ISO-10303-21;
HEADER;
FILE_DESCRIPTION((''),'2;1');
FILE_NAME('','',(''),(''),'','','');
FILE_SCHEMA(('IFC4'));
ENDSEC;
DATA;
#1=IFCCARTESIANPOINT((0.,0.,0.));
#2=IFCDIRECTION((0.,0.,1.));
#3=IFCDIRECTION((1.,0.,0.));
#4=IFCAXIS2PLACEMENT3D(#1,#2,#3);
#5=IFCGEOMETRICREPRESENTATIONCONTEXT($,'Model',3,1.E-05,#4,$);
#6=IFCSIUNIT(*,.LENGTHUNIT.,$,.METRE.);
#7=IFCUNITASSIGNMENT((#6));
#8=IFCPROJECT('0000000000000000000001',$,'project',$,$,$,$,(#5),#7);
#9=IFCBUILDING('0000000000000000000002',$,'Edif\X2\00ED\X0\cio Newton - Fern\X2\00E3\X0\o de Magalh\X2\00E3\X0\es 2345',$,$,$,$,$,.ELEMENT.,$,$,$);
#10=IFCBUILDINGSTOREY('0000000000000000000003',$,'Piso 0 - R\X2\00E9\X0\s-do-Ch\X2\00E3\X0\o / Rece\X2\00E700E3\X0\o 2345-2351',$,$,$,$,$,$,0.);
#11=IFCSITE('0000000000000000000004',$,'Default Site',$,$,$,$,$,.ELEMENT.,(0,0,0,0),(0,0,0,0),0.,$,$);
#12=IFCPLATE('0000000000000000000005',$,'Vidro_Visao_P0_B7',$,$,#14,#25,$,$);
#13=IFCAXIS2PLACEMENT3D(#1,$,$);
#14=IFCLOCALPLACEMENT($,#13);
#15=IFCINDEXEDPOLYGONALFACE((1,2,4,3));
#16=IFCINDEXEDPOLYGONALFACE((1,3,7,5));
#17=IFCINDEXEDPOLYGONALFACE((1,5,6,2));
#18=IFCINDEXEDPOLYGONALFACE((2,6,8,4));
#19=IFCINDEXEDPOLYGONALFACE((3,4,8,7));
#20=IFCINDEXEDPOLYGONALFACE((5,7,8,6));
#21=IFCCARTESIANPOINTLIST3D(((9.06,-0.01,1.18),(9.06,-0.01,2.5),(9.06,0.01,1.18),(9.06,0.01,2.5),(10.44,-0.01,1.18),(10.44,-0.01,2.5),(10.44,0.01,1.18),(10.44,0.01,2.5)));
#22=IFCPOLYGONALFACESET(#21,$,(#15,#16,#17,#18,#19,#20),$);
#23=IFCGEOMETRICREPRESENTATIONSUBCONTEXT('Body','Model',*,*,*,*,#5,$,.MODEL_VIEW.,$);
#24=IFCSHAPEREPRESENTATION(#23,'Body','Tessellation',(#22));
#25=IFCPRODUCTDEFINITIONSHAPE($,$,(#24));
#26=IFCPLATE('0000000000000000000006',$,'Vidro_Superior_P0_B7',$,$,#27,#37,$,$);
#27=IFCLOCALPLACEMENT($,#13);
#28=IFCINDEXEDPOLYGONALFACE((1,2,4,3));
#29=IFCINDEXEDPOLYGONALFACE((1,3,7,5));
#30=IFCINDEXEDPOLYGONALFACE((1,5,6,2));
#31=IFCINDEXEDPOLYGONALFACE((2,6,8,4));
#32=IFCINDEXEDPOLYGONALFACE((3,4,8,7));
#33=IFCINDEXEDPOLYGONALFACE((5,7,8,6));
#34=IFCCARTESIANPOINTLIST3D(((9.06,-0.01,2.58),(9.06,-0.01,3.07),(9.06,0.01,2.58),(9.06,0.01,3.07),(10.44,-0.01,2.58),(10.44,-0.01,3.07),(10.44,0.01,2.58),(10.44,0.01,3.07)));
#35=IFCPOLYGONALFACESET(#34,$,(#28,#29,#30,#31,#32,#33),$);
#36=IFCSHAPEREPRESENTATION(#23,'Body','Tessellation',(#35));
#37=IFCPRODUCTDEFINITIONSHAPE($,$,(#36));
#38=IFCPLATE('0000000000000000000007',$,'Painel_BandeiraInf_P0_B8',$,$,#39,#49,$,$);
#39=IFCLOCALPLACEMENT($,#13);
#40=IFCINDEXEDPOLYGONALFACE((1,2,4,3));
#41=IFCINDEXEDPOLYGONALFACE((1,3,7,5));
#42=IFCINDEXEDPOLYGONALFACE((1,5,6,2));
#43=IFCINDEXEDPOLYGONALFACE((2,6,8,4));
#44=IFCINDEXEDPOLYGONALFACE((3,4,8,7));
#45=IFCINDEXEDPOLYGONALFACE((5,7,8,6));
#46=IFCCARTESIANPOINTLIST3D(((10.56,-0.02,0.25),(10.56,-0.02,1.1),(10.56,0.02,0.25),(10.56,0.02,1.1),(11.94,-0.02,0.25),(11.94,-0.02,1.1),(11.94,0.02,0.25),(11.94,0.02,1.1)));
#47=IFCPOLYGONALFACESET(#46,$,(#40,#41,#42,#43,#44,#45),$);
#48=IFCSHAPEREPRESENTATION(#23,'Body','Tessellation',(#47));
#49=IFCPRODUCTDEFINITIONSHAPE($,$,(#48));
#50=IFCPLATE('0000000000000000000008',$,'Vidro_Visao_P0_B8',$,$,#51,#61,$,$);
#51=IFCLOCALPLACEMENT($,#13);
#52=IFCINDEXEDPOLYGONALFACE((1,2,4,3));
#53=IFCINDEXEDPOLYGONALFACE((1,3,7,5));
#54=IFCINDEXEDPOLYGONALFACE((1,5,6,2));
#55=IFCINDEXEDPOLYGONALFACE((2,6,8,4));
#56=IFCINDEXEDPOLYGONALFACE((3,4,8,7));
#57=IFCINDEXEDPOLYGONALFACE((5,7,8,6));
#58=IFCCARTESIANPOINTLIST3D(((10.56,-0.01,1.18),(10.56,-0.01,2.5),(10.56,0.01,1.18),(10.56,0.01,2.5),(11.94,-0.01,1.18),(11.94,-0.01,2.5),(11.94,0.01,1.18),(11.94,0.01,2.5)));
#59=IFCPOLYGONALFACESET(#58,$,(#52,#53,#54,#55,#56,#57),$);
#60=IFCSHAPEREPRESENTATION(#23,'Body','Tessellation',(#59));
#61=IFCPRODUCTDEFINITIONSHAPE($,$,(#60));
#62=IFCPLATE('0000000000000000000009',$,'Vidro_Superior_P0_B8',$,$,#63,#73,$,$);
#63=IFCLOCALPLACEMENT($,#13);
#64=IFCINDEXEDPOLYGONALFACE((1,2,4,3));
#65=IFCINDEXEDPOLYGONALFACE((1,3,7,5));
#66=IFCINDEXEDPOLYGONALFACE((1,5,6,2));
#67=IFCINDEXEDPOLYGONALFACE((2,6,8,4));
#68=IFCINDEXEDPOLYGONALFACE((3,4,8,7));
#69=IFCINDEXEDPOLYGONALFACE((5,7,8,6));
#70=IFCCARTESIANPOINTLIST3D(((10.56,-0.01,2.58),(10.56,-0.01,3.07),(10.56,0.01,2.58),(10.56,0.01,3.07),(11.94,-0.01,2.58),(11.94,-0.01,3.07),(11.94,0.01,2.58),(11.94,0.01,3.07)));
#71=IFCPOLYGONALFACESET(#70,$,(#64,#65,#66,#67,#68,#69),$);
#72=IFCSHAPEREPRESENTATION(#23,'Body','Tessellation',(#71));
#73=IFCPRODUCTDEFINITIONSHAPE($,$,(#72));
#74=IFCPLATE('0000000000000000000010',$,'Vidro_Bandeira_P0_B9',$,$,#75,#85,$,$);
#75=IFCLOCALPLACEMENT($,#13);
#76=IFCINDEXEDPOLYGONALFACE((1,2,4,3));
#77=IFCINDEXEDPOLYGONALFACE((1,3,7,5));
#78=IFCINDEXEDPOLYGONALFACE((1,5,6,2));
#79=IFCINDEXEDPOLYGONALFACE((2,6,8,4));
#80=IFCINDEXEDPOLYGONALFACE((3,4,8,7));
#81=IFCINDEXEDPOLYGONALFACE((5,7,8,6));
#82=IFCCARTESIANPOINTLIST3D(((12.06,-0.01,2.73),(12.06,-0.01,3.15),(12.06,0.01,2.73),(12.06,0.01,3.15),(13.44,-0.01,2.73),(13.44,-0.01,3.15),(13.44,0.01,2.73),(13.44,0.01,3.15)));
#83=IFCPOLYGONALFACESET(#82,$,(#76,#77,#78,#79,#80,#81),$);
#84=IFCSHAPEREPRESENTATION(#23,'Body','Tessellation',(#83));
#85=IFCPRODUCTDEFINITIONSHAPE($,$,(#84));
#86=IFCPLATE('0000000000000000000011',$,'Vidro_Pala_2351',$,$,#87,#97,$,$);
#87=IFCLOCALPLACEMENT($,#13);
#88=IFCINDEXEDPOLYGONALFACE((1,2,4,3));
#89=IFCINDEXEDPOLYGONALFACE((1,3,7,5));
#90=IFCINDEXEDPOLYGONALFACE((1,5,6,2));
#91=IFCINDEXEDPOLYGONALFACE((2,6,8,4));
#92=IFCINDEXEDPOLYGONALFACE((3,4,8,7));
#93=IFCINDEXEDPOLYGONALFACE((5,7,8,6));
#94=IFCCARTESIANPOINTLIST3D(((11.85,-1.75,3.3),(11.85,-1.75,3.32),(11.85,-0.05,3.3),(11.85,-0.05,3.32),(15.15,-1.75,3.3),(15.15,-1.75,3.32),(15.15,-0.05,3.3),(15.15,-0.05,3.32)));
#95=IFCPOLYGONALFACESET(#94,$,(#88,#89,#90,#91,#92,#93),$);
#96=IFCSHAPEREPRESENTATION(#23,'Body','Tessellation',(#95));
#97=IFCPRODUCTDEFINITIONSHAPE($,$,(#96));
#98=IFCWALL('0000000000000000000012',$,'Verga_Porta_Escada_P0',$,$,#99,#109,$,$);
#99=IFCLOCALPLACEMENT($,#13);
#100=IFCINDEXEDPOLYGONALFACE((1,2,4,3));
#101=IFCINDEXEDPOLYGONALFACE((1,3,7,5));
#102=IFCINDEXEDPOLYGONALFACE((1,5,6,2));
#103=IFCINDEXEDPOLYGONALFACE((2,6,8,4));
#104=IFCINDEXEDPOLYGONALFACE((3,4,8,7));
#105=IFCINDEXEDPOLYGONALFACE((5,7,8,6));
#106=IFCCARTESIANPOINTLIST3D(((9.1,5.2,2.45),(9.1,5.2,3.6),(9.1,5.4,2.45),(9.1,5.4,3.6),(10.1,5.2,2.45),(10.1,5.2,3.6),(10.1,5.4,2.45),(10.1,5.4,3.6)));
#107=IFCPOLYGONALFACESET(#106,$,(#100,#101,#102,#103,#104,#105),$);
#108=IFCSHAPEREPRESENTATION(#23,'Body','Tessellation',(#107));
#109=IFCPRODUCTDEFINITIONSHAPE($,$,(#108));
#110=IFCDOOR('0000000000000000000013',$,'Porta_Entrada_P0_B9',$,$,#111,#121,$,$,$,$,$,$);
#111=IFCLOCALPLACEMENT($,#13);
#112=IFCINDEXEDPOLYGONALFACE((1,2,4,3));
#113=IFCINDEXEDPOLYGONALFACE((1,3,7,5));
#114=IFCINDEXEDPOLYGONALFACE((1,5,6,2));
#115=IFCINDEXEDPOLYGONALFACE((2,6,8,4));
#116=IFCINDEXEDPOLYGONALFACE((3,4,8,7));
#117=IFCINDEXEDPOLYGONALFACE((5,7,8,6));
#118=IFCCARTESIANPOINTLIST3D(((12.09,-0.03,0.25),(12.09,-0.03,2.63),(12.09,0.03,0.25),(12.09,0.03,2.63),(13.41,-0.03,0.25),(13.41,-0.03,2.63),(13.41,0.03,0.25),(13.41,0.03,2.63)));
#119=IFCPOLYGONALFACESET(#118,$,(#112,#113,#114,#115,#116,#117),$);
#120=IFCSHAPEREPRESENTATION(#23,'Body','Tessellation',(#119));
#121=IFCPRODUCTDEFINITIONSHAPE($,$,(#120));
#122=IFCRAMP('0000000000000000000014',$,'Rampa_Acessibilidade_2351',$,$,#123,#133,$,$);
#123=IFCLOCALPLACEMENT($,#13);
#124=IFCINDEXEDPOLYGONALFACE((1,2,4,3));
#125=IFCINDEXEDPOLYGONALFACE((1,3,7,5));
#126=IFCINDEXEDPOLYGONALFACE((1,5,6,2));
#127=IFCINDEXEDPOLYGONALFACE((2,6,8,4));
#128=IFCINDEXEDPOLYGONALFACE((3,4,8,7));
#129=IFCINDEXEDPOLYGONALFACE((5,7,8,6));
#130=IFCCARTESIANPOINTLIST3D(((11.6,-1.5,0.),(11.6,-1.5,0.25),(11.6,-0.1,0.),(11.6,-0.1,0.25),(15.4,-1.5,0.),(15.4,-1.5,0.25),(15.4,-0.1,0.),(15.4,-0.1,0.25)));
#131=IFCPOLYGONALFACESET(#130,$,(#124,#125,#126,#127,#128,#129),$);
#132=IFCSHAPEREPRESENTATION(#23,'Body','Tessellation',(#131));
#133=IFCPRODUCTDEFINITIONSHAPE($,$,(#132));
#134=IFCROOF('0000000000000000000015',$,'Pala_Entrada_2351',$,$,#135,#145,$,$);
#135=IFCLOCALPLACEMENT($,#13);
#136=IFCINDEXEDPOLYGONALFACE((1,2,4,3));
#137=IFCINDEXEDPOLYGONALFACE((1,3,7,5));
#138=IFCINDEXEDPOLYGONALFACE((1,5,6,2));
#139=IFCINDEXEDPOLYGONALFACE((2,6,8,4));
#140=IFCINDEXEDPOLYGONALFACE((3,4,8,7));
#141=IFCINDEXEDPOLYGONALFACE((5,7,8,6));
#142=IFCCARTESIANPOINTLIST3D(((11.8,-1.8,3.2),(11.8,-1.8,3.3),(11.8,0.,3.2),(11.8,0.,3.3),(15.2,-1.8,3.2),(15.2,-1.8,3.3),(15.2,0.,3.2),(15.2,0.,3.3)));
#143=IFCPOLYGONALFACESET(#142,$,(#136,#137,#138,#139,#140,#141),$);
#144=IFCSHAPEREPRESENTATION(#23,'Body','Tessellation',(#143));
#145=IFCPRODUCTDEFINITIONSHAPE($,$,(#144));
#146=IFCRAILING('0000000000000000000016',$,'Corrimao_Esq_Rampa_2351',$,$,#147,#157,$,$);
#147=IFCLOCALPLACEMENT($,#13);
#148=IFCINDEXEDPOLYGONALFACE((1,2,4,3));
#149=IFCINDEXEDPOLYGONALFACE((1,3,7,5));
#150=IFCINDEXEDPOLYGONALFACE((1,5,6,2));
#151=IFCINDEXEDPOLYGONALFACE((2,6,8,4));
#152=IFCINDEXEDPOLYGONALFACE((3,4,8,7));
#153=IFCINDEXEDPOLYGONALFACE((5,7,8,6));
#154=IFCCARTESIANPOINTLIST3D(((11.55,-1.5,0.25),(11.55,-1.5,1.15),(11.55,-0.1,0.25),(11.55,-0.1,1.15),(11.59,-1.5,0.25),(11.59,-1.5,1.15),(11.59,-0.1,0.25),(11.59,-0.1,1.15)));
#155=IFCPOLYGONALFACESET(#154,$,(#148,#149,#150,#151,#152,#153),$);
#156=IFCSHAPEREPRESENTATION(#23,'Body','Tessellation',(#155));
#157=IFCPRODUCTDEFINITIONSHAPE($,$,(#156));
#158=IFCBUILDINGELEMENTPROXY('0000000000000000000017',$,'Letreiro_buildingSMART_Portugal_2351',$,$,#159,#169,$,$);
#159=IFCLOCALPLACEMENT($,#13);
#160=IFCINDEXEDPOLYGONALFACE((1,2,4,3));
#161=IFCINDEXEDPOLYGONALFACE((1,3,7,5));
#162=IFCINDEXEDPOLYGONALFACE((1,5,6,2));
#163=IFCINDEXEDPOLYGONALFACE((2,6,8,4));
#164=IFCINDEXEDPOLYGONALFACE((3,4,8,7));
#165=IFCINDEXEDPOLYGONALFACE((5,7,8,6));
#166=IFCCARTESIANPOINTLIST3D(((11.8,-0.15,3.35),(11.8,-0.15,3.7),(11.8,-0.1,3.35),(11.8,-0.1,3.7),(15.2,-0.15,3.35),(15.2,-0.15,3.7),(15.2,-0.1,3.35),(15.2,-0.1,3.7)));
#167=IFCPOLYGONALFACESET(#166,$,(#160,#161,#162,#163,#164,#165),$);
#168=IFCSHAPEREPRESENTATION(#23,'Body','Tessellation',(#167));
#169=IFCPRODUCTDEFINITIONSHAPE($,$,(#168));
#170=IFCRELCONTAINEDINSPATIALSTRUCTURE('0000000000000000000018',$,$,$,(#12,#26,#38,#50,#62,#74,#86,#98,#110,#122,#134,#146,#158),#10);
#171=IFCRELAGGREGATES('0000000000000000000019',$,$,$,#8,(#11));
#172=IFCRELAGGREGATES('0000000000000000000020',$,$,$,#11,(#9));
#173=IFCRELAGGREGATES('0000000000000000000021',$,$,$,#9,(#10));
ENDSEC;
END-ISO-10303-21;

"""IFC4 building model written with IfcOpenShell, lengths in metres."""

from ifc_helpers import new_model, si_unit, frame, frame_2d, origin_with_axes, place, context, subcontext, project, spatial, rectangle, extrude, element, save


model = new_model("IFC4")

# Units and contexts
model_context = context("Model", 3, precision=1e-05, world=origin_with_axes())
body_context = subcontext(model_context, "Body", "Model", "MODEL_VIEW")
ifc_project = project(units=[si_unit("LENGTHUNIT", "METRE")], contexts=[model_context])

# Site, building, storey
site = spatial("IfcSite", under=ifc_project, Name="Default Site", CompositionType="ELEMENT", RefLatitude=(0, 0, 0, 0), RefLongitude=(0, 0, 0, 0), RefElevation=0.0)
building = spatial("IfcBuilding", under=site, Name="Edifício Newton - Fernão de Magalhães 2345", CompositionType="ELEMENT")
storey = spatial("IfcBuildingStorey", under=building, Name="Piso 0 - Rés-do-Chão / Receção 2345-2351", Elevation=0.0)

# Plates
plate_1_placement = place(None, frame((9.06, -0.01, 1.18), z_axis=(0.0, 0.0, 1.0), x_axis=(1.0, 0.0, 0.0)))
element("IfcPlate", 1, at=plate_1_placement, inside=storey, Name="Vidro_Visao_P0_B7", context=body_context, shape_type="SweptSolid", body=[
    extrude(rectangle(XDim=1.38, YDim=0.02, at=frame_2d((0.69, 0.01))), origin_with_axes(), (0.0, 0.0, 1.0), 1.32),
])
plate_2_placement = place(None, frame((9.06, -0.01, 2.58), z_axis=(0.0, 0.0, 1.0), x_axis=(1.0, 0.0, 0.0)))
element("IfcPlate", 2, at=plate_2_placement, inside=storey, Name="Vidro_Superior_P0_B7", context=body_context, shape_type="SweptSolid", body=[
    extrude(rectangle(XDim=1.38, YDim=0.02, at=frame_2d((0.69, 0.01))), origin_with_axes(), (0.0, 0.0, 1.0), 0.49),
])
plate_3_placement = place(None, frame((10.56, -0.02, 0.25), z_axis=(0.0, 0.0, 1.0), x_axis=(1.0, 0.0, 0.0)))
element("IfcPlate", 3, at=plate_3_placement, inside=storey, Name="Painel_BandeiraInf_P0_B8", context=body_context, shape_type="SweptSolid", body=[
    extrude(rectangle(XDim=1.38, YDim=0.04, at=frame_2d((0.69, 0.02))), origin_with_axes(), (0.0, 0.0, 1.0), 0.85),
])
plate_4_placement = place(None, frame((10.56, -0.01, 1.18), z_axis=(0.0, 0.0, 1.0), x_axis=(1.0, 0.0, 0.0)))
element("IfcPlate", 4, at=plate_4_placement, inside=storey, Name="Vidro_Visao_P0_B8", context=body_context, shape_type="SweptSolid", body=[
    extrude(rectangle(XDim=1.38, YDim=0.02, at=frame_2d((0.69, 0.01))), origin_with_axes(), (0.0, 0.0, 1.0), 1.32),
])
plate_5_placement = place(None, frame((10.56, -0.01, 2.58), z_axis=(0.0, 0.0, 1.0), x_axis=(1.0, 0.0, 0.0)))
element("IfcPlate", 5, at=plate_5_placement, inside=storey, Name="Vidro_Superior_P0_B8", context=body_context, shape_type="SweptSolid", body=[
    extrude(rectangle(XDim=1.38, YDim=0.02, at=frame_2d((0.69, 0.01))), origin_with_axes(), (0.0, 0.0, 1.0), 0.49),
])
plate_6_placement = place(None, frame((12.06, -0.01, 2.73), z_axis=(0.0, 0.0, 1.0), x_axis=(1.0, 0.0, 0.0)))
element("IfcPlate", 6, at=plate_6_placement, inside=storey, Name="Vidro_Bandeira_P0_B9", context=body_context, shape_type="SweptSolid", body=[
    extrude(rectangle(XDim=1.38, YDim=0.02, at=frame_2d((0.69, 0.01))), origin_with_axes(), (0.0, 0.0, 1.0), 0.42),
])
plate_7_placement = place(None, frame((11.85, -1.75, 3.3), z_axis=(0.0, 0.0, 1.0), x_axis=(1.0, 0.0, 0.0)))
element("IfcPlate", 7, at=plate_7_placement, inside=storey, Name="Vidro_Pala_2351", context=body_context, shape_type="SweptSolid", body=[
    extrude(rectangle(XDim=3.3, YDim=1.7, at=frame_2d((1.65, 0.85))), origin_with_axes(), (0.0, 0.0, 1.0), 0.02),
])

# Wall
wall_placement = place(None, frame((9.1, 5.2, 2.45), z_axis=(0.0, 0.0, 1.0), x_axis=(1.0, 0.0, 0.0)))
element("IfcWall", 8, at=wall_placement, inside=storey, Name="Verga_Porta_Escada_P0", context=body_context, shape_type="SweptSolid", body=[
    extrude(rectangle(XDim=1.0, YDim=0.2, at=frame_2d((0.5, 0.1))), origin_with_axes(), (0.0, 0.0, 1.0), 1.15),
])

# Door
door_placement = place(None, frame((12.09, -0.03, 0.25), z_axis=(0.0, 0.0, 1.0), x_axis=(1.0, 0.0, 0.0)))
element("IfcDoor", 9, at=door_placement, inside=storey, Name="Porta_Entrada_P0_B9", context=body_context, shape_type="SweptSolid", body=[
    extrude(rectangle(XDim=1.32, YDim=0.06, at=frame_2d((0.66, 0.03))), origin_with_axes(), (0.0, 0.0, 1.0), 2.38),
])

# Ramp
ramp_placement = place(None, frame((11.6, -1.5, 0.0), z_axis=(0.0, 0.0, 1.0), x_axis=(1.0, 0.0, 0.0)))
element("IfcRamp", 10, at=ramp_placement, inside=storey, Name="Rampa_Acessibilidade_2351", context=body_context, shape_type="SweptSolid", body=[
    extrude(rectangle(XDim=3.8, YDim=1.4, at=frame_2d((1.9, 0.7))), origin_with_axes(), (0.0, 0.0, 1.0), 0.25),
])

# Roof
roof_placement = place(None, frame((11.8, -1.8, 3.2), z_axis=(0.0, 0.0, 1.0), x_axis=(1.0, 0.0, 0.0)))
element("IfcRoof", 11, at=roof_placement, inside=storey, Name="Pala_Entrada_2351", context=body_context, shape_type="SweptSolid", body=[
    extrude(rectangle(XDim=3.4, YDim=1.8, at=frame_2d((1.7, 0.9))), origin_with_axes(), (0.0, 0.0, 1.0), 0.1),
])

# Railing
railing_placement = place(None, frame((11.55, -1.5, 0.25), z_axis=(0.0, 0.0, 1.0), x_axis=(1.0, 0.0, 0.0)))
element("IfcRailing", 12, at=railing_placement, inside=storey, Name="Corrimao_Esq_Rampa_2351", context=body_context, shape_type="SweptSolid", body=[
    extrude(rectangle(XDim=0.04, YDim=1.4, at=frame_2d((0.02, 0.7))), origin_with_axes(), (0.0, 0.0, 1.0), 0.9),
])

# Building element proxy
proxy_placement = place(None, frame((11.8, -0.15, 3.35), z_axis=(0.0, 0.0, 1.0), x_axis=(1.0, 0.0, 0.0)))
element("IfcBuildingElementProxy", 13, at=proxy_placement, inside=storey, Name="Letreiro_buildingSMART_Portugal_2351", context=body_context, shape_type="SweptSolid", body=[
    extrude(rectangle(XDim=3.4, YDim=0.05, at=frame_2d((1.7, 0.025))), origin_with_axes(), (0.0, 0.0, 1.0), 0.35),
])

save(model, "model.ifc")
